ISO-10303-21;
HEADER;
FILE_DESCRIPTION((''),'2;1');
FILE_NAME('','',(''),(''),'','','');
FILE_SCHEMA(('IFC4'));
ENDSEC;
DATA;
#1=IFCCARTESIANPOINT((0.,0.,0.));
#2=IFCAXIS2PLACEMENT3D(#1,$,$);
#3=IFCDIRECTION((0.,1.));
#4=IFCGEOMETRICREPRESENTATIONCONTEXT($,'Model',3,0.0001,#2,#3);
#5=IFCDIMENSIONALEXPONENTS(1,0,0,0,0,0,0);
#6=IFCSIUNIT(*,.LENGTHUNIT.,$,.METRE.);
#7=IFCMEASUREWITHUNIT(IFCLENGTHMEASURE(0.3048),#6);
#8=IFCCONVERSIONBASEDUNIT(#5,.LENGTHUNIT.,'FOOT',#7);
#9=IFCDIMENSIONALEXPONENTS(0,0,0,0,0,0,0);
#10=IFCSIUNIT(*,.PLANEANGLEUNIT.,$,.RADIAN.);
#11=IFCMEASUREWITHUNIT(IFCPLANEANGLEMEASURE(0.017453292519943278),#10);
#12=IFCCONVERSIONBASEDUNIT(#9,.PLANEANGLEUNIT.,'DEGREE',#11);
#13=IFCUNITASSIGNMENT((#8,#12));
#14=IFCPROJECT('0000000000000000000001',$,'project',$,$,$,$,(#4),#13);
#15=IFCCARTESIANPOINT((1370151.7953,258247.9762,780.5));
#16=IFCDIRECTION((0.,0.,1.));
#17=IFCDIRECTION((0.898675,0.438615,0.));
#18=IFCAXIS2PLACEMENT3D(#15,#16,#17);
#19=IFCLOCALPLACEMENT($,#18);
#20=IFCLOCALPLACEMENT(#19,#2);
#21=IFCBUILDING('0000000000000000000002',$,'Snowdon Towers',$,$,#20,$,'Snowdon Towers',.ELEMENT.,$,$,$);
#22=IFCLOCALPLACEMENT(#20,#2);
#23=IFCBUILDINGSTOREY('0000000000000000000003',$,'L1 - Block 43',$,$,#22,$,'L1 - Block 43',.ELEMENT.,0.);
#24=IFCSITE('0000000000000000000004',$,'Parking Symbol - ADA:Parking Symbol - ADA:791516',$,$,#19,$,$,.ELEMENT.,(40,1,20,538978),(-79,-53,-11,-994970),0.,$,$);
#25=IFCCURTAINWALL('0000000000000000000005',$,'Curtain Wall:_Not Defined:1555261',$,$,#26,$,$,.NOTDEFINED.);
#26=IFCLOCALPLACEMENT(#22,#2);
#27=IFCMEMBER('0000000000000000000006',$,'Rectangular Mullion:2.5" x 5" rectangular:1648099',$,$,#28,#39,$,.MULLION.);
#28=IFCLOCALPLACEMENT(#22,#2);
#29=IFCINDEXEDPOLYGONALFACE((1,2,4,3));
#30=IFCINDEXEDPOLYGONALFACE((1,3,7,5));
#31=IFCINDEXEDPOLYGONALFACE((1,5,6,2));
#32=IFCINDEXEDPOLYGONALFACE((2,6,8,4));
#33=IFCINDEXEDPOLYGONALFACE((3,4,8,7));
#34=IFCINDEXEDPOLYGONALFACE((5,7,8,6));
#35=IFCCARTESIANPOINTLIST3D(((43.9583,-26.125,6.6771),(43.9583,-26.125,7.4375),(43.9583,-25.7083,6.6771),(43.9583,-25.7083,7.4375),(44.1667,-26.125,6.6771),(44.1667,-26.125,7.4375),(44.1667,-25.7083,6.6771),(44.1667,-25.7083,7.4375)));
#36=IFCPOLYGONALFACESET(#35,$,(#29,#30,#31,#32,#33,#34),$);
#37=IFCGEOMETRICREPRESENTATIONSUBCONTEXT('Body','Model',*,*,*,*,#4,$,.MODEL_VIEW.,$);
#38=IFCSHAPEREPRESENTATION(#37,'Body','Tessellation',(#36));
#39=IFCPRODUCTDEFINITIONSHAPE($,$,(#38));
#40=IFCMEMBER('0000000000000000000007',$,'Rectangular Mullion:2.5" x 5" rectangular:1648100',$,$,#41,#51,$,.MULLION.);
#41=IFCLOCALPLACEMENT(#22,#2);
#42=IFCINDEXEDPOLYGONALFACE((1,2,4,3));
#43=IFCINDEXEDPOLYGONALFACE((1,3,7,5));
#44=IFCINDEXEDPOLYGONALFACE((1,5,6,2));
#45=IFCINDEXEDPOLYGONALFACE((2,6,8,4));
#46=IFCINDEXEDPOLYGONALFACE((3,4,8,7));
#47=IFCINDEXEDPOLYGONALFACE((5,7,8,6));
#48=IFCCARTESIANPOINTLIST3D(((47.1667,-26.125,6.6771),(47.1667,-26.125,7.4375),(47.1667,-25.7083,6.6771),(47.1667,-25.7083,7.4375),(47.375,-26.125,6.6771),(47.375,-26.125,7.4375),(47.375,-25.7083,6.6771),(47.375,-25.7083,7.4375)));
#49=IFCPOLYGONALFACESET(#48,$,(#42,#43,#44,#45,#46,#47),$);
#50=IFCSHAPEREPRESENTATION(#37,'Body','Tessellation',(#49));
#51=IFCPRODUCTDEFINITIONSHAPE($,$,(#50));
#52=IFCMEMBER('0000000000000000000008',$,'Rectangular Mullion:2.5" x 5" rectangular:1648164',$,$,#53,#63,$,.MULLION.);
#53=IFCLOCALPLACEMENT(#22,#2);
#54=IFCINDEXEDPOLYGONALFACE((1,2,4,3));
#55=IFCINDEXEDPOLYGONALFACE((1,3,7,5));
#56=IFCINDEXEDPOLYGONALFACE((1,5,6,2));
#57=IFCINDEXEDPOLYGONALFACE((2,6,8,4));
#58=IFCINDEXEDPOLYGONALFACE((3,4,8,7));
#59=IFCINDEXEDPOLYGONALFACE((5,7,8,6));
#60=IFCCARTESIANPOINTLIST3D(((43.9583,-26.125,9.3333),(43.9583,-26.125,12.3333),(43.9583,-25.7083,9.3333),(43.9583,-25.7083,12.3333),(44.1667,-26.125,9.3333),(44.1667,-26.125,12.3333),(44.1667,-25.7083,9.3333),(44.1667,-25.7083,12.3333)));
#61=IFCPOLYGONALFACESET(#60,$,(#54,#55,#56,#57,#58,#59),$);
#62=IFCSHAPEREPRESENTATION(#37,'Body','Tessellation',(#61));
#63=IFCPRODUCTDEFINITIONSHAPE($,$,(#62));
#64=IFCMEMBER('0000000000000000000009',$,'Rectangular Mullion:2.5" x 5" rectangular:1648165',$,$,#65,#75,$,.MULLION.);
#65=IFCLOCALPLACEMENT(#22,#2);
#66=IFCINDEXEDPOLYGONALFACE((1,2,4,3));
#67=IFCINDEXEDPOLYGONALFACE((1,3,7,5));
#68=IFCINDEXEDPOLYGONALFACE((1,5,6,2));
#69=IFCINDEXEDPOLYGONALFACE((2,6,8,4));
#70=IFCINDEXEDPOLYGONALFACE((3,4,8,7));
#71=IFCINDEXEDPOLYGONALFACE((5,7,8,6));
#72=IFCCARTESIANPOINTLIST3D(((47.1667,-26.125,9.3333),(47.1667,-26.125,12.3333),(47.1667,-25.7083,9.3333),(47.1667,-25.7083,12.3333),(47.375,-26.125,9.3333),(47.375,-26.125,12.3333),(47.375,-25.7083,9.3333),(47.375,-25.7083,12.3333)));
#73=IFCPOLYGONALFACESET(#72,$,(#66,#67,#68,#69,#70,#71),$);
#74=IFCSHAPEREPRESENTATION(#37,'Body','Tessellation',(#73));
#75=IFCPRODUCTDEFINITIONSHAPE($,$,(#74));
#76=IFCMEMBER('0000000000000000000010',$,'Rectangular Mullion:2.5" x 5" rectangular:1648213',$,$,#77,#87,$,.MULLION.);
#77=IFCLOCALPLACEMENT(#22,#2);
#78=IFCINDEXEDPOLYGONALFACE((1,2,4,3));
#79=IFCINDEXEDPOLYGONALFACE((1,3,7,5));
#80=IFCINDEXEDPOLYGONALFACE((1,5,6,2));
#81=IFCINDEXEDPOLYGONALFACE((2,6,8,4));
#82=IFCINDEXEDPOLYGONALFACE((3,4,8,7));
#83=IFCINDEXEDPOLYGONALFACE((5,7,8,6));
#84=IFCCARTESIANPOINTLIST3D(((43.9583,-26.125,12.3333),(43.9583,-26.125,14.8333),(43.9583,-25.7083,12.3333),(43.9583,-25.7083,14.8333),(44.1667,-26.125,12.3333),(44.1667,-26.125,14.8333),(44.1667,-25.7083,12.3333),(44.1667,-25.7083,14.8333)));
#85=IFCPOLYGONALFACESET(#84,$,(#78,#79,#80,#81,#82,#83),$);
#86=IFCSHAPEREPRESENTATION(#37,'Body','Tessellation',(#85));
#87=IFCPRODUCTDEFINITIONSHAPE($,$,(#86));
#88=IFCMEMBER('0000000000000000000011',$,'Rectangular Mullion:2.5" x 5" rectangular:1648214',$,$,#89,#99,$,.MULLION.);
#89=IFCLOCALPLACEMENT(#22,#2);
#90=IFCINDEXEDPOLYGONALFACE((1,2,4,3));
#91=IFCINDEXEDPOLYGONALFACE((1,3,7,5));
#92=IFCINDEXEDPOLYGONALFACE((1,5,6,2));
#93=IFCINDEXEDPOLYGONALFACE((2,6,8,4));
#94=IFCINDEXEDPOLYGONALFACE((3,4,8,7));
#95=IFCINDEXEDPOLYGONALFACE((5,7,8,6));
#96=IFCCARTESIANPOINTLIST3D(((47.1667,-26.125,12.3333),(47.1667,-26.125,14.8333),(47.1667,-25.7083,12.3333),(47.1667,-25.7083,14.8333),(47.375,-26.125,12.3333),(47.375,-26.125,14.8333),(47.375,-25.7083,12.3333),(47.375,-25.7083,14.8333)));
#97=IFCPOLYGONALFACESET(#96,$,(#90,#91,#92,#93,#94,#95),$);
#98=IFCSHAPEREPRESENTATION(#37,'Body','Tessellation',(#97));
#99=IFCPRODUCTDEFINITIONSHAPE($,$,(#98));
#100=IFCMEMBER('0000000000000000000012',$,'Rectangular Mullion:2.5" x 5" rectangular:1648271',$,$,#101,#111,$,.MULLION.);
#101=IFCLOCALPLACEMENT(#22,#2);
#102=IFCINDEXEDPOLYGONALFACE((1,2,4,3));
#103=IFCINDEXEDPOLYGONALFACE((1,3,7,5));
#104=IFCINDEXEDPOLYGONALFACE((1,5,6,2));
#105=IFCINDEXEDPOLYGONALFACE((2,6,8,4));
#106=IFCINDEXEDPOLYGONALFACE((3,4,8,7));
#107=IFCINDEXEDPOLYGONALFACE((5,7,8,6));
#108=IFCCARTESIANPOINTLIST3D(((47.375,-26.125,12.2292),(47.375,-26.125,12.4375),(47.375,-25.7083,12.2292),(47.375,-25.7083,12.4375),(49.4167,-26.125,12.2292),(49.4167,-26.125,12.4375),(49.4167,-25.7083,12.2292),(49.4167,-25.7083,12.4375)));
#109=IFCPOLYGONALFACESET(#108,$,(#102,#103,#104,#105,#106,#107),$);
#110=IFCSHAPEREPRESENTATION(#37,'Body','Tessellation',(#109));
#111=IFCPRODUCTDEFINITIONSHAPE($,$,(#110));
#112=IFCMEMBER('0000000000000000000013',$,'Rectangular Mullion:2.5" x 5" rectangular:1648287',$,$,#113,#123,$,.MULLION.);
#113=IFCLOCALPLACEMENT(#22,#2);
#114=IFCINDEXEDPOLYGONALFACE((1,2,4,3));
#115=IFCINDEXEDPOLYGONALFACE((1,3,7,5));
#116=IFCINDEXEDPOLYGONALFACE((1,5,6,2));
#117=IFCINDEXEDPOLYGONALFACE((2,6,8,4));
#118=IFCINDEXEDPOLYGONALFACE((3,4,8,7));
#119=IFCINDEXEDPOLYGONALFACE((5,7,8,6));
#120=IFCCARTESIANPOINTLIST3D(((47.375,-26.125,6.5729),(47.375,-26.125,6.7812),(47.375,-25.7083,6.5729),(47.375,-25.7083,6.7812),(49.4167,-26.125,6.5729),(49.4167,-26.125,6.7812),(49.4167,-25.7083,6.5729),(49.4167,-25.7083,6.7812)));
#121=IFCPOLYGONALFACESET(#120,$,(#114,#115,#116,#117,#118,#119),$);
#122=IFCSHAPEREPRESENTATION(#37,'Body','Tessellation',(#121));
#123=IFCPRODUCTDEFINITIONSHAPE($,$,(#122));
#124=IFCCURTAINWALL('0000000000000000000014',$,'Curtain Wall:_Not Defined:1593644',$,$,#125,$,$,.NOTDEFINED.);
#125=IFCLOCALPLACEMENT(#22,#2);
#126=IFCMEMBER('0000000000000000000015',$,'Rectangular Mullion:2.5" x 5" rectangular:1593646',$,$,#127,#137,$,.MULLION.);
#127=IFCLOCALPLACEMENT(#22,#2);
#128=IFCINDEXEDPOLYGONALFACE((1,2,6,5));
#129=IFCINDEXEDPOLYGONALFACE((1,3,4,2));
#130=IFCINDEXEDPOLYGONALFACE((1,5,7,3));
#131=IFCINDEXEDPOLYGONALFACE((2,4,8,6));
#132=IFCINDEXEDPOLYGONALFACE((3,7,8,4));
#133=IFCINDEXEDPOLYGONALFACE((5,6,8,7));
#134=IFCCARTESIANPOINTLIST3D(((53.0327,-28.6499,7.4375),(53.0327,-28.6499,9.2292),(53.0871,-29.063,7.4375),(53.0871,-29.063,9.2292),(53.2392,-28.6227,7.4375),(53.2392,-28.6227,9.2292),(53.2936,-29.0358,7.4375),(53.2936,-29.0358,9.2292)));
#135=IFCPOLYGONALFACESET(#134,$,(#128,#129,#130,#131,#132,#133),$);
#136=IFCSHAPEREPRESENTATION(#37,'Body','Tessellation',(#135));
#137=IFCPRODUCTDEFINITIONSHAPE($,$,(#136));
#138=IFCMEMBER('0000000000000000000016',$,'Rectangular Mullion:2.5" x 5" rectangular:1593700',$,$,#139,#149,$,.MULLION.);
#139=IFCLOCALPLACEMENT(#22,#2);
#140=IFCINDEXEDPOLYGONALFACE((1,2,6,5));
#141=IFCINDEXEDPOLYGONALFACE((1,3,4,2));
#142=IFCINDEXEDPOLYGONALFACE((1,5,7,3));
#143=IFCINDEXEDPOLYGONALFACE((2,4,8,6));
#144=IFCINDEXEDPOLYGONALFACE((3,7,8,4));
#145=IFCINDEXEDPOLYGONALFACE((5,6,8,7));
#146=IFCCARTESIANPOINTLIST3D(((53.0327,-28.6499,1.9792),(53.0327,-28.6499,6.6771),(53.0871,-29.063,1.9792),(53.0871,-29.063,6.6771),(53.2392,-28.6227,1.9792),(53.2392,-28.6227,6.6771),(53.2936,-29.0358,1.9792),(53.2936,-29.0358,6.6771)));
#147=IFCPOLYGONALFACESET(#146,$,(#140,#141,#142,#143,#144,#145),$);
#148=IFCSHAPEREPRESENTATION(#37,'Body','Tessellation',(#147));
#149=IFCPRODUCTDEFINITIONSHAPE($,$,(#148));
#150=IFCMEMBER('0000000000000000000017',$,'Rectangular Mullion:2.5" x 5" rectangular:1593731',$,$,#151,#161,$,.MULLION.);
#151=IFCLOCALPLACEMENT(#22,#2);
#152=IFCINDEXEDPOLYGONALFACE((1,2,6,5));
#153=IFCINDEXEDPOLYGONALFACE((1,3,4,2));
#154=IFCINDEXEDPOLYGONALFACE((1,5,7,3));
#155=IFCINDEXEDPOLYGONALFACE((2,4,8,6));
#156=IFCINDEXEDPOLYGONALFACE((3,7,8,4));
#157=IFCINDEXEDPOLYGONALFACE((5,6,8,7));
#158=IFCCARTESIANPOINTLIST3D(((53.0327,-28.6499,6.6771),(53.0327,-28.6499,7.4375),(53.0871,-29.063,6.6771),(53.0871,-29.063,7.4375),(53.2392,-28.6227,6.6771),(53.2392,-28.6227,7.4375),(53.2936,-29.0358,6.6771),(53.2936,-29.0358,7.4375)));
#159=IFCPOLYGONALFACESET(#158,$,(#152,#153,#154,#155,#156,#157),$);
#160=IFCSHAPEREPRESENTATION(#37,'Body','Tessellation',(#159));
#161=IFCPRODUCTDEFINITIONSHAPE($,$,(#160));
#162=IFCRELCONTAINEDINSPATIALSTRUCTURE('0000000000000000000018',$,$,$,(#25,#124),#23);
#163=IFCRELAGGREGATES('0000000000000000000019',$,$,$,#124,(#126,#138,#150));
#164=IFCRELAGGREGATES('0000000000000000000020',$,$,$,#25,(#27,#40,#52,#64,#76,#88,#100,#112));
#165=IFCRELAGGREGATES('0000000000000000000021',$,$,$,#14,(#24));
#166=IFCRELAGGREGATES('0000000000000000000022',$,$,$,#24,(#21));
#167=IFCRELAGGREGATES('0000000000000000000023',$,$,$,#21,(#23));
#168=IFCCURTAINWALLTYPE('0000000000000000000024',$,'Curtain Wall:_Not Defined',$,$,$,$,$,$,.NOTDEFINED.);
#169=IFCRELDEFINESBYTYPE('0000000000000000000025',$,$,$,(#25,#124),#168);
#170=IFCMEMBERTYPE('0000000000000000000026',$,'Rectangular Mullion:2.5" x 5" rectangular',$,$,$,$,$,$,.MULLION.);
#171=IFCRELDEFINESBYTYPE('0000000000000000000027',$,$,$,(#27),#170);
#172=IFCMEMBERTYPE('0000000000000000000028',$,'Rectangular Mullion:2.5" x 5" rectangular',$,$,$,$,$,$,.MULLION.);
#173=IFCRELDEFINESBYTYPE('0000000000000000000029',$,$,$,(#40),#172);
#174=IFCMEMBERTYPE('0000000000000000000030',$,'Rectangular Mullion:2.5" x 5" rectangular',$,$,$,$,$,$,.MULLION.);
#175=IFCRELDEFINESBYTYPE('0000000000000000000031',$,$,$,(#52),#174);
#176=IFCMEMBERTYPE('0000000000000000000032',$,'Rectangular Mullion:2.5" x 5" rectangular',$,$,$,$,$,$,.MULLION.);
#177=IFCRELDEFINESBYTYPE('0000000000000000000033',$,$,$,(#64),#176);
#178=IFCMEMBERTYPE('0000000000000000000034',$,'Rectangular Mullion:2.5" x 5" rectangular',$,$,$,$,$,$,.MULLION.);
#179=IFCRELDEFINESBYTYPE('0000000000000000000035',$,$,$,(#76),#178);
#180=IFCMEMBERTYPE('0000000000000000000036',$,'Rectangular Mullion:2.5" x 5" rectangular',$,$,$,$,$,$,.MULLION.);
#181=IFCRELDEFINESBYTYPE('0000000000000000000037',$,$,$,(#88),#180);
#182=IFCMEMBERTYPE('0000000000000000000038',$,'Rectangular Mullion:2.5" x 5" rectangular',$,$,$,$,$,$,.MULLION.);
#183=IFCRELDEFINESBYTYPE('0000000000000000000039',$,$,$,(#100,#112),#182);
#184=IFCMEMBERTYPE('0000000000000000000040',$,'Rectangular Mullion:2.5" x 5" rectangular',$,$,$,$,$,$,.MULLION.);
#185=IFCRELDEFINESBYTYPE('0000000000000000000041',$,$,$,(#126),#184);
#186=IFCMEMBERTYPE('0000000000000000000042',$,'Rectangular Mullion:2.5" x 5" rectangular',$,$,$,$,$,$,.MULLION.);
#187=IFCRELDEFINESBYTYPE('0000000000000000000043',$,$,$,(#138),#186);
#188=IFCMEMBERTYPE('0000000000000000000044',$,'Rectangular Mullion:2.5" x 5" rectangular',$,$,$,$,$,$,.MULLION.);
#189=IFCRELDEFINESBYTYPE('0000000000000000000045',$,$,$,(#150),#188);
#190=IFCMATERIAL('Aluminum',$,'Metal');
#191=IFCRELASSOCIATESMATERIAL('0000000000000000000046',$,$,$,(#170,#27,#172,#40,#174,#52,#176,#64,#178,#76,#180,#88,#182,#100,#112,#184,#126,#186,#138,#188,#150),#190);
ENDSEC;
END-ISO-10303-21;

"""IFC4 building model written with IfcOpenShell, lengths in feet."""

from ifc_helpers import new_model, entity, si_unit, converted_unit, direction, frame, origin, place, context, subcontext, project, spatial, indexed_curve, outline, extrude, source, transform, mapped, material, type_object, type_shapes, element, aggregate, save


model = new_model("IFC4")

# Units and contexts
model_context = context("Model", 3, precision=0.0001, world=origin(), true_north=direction((0.0, 1.0)))
body_context = subcontext(model_context, "Body", "Model", "MODEL_VIEW")
ifc_project = project(units=[converted_unit("LENGTHUNIT", "FOOT", entity("IfcLengthMeasure", 0.3048), si_unit("LENGTHUNIT", "METRE"), dimensions=[1, 0, 0, 0, 0, 0, 0]), converted_unit("PLANEANGLEUNIT", "DEGREE", entity("IfcPlaneAngleMeasure", 0.017453292519943278), si_unit("PLANEANGLEUNIT", "RADIAN"), dimensions=[0, 0, 0, 0, 0, 0, 0])], contexts=[model_context])

# Site, building, storey
site_placement = place(None, frame((1370151.7953, 258247.9762, 780.5), z_axis=(0.0, 0.0, 1.0), x_axis=(0.898675, 0.438615, 0.0)))
site = spatial("IfcSite", under=ifc_project, at=site_placement, Name="Parking Symbol - ADA:Parking Symbol - ADA:791516", CompositionType="ELEMENT", RefLatitude=(40, 1, 20, 538978), RefLongitude=(-79, -53, -11, -994970), RefElevation=0.0)
building_placement = place(site_placement, origin())
building = spatial("IfcBuilding", under=site, at=building_placement, Name="Snowdon Towers", LongName="Snowdon Towers", CompositionType="ELEMENT")
storey_placement = place(building_placement, origin())
storey = spatial("IfcBuildingStorey", under=building, at=storey_placement, Name="L1 - Block 43", LongName="L1 - Block 43", CompositionType="ELEMENT", Elevation=0.0)

# Curtain walls, members
curtain_wall_type = type_object("IfcCurtainWallType", Name="Curtain Wall:_Not Defined", PredefinedType="NOTDEFINED")
curtain_wall_1_placement = place(storey_placement, origin())
curtain_wall_1 = element("IfcCurtainWall", 1, at=curtain_wall_1_placement, inside=storey, type_object=curtain_wall_type, Name="Curtain Wall:_Not Defined:1555261", PredefinedType="NOTDEFINED")
ifc_material_1 = material(Name="Aluminum", Category="Metal")
member_type_1 = type_object("IfcMemberType", Name="Rectangular Mullion:2.5\" x 5\" rectangular", PredefinedType="MULLION", material=ifc_material_1)
shared_shape_1 = source(origin(), body_context, "Body", "SweptSolid", [
    extrude(outline(indexed_curve([(-0.1042, -0.2083), (0.1042, -0.2083), (0.1042, 0.2083), (-0.1042, 0.2083), (-0.1042, -0.2083)], self_intersect=False)), frame((-0.1042, 0.0, -0.7604), z_axis=(0.0, 0.0, 1.0), x_axis=(-1.0, 0.0, 0.0)), (0.0, 0.0, 1.0), 0.7604),
])
type_shapes(member_type_1, [shared_shape_1])
member_1_placement = place(curtain_wall_1_placement, frame((43.9583, -25.9167, 6.6771), z_axis=(0.0, 0.0, -1.0), x_axis=(-1.0, 0.0, 0.0)))
member_1 = element("IfcMember", 2, at=member_1_placement, type_object=member_type_1, material=ifc_material_1, Name="Rectangular Mullion:2.5\" x 5\" rectangular:1648099", PredefinedType="MULLION", context=body_context, shape_type="MappedRepresentation", body=[
    mapped(shared_shape_1, transform((0.0, 0.0, 0.0), scale=1.0)),
])
member_type_2 = type_object("IfcMemberType", Name="Rectangular Mullion:2.5\" x 5\" rectangular", PredefinedType="MULLION", material=ifc_material_1)
shared_shape_2 = source(origin(), body_context, "Body", "SweptSolid", [
    extrude(outline(indexed_curve([(-0.1042, -0.2083), (0.1042, -0.2083), (0.1042, 0.2083), (-0.1042, 0.2083), (-0.1042, -0.2083)], self_intersect=False)), frame((0.0, 0.0, -0.7604), z_axis=(0.0, 0.0, 1.0), x_axis=(-1.0, 0.0, 0.0)), (0.0, 0.0, 1.0), 0.7604),
])
type_shapes(member_type_2, [shared_shape_2])
member_2_placement = place(curtain_wall_1_placement, frame((47.2708, -25.9167, 6.6771), z_axis=(0.0, 0.0, -1.0), x_axis=(-1.0, 0.0, 0.0)))
member_2 = element("IfcMember", 3, at=member_2_placement, type_object=member_type_2, material=ifc_material_1, Name="Rectangular Mullion:2.5\" x 5\" rectangular:1648100", PredefinedType="MULLION", context=body_context, shape_type="MappedRepresentation", body=[
    mapped(shared_shape_2, transform((0.0, 0.0, 0.0), scale=1.0)),
])
member_type_3 = type_object("IfcMemberType", Name="Rectangular Mullion:2.5\" x 5\" rectangular", PredefinedType="MULLION", material=ifc_material_1)
shared_shape_3 = source(origin(), body_context, "Body", "SweptSolid", [
    extrude(outline(indexed_curve([(-0.1042, -0.2083), (0.1042, -0.2083), (0.1042, 0.2083), (-0.1042, 0.2083), (-0.1042, -0.2083)], self_intersect=False)), frame((-0.1042, 0.0, -3.0), z_axis=(0.0, 0.0, 1.0), x_axis=(-1.0, 0.0, 0.0)), (0.0, 0.0, 1.0), 3.0),
])
type_shapes(member_type_3, [shared_shape_3])
member_3_placement = place(curtain_wall_1_placement, frame((43.9583, -25.9167, 9.3333), z_axis=(0.0, 0.0, -1.0), x_axis=(-1.0, 0.0, 0.0)))
member_3 = element("IfcMember", 4, at=member_3_placement, type_object=member_type_3, material=ifc_material_1, Name="Rectangular Mullion:2.5\" x 5\" rectangular:1648164", PredefinedType="MULLION", context=body_context, shape_type="MappedRepresentation", body=[
    mapped(shared_shape_3, transform((0.0, 0.0, 0.0), scale=1.0)),
])
member_type_4 = type_object("IfcMemberType", Name="Rectangular Mullion:2.5\" x 5\" rectangular", PredefinedType="MULLION", material=ifc_material_1)
shared_shape_4 = source(origin(), body_context, "Body", "SweptSolid", [
    extrude(outline(indexed_curve([(-0.1042, -0.2083), (0.1042, -0.2083), (0.1042, 0.2083), (-0.1042, 0.2083), (-0.1042, -0.2083)], self_intersect=False)), frame((0.0, 0.0, -3.0), z_axis=(0.0, 0.0, 1.0), x_axis=(-1.0, 0.0, 0.0)), (0.0, 0.0, 1.0), 3.0),
])
type_shapes(member_type_4, [shared_shape_4])
member_4_placement = place(curtain_wall_1_placement, frame((47.2708, -25.9167, 9.3333), z_axis=(0.0, 0.0, -1.0), x_axis=(-1.0, 0.0, 0.0)))
member_4 = element("IfcMember", 5, at=member_4_placement, type_object=member_type_4, material=ifc_material_1, Name="Rectangular Mullion:2.5\" x 5\" rectangular:1648165", PredefinedType="MULLION", context=body_context, shape_type="MappedRepresentation", body=[
    mapped(shared_shape_4, transform((0.0, 0.0, 0.0), scale=1.0)),
])
member_type_5 = type_object("IfcMemberType", Name="Rectangular Mullion:2.5\" x 5\" rectangular", PredefinedType="MULLION", material=ifc_material_1)
shared_shape_5 = source(origin(), body_context, "Body", "SweptSolid", [
    extrude(outline(indexed_curve([(-0.1042, -0.2083), (0.1042, -0.2083), (0.1042, 0.2083), (-0.1042, 0.2083), (-0.1042, -0.2083)], self_intersect=False)), frame((-0.1042, 0.0, -2.5), z_axis=(0.0, 0.0, 1.0), x_axis=(-1.0, 0.0, 0.0)), (0.0, 0.0, 1.0), 2.5),
])
type_shapes(member_type_5, [shared_shape_5])
member_5_placement = place(curtain_wall_1_placement, frame((43.9583, -25.9167, 12.3333), z_axis=(0.0, 0.0, -1.0), x_axis=(-1.0, 0.0, 0.0)))
member_5 = element("IfcMember", 6, at=member_5_placement, type_object=member_type_5, material=ifc_material_1, Name="Rectangular Mullion:2.5\" x 5\" rectangular:1648213", PredefinedType="MULLION", context=body_context, shape_type="MappedRepresentation", body=[
    mapped(shared_shape_5, transform((0.0, 0.0, 0.0), scale=1.0)),
])
member_type_6 = type_object("IfcMemberType", Name="Rectangular Mullion:2.5\" x 5\" rectangular", PredefinedType="MULLION", material=ifc_material_1)
shared_shape_6 = source(origin(), body_context, "Body", "SweptSolid", [
    extrude(outline(indexed_curve([(-0.1042, -0.2083), (0.1042, -0.2083), (0.1042, 0.2083), (-0.1042, 0.2083), (-0.1042, -0.2083)], self_intersect=False)), frame((0.0, 0.0, -2.5), z_axis=(0.0, 0.0, 1.0), x_axis=(-1.0, 0.0, 0.0)), (0.0, 0.0, 1.0), 2.5),
])
type_shapes(member_type_6, [shared_shape_6])
member_6_placement = place(curtain_wall_1_placement, frame((47.2708, -25.9167, 12.3333), z_axis=(0.0, 0.0, -1.0), x_axis=(-1.0, 0.0, 0.0)))
member_6 = element("IfcMember", 7, at=member_6_placement, type_object=member_type_6, material=ifc_material_1, Name="Rectangular Mullion:2.5\" x 5\" rectangular:1648214", PredefinedType="MULLION", context=body_context, shape_type="MappedRepresentation", body=[
    mapped(shared_shape_6, transform((0.0, 0.0, 0.0), scale=1.0)),
])
member_type_7 = type_object("IfcMemberType", Name="Rectangular Mullion:2.5\" x 5\" rectangular", PredefinedType="MULLION", material=ifc_material_1)
shared_shape_7 = source(origin(), body_context, "Body", "SweptSolid", [
    extrude(outline(indexed_curve([(-0.1042, -0.2083), (0.1042, -0.2083), (0.1042, 0.2083), (-0.1042, 0.2083), (-0.1042, -0.2083)], self_intersect=False)), frame((0.0, 0.0, -2.0417), z_axis=(0.0, 0.0, 1.0), x_axis=(-1.0, 0.0, 0.0)), (0.0, 0.0, 1.0), 2.0417),
])
type_shapes(member_type_7, [shared_shape_7])
member_7_placement = place(curtain_wall_1_placement, frame((47.375, -25.9167, 12.3333), z_axis=(-1.0, 0.0, 0.0), x_axis=(0.0, 0.0, 1.0)))
member_7 = element("IfcMember", 8, at=member_7_placement, type_object=member_type_7, material=ifc_material_1, Name="Rectangular Mullion:2.5\" x 5\" rectangular:1648271", PredefinedType="MULLION", context=body_context, shape_type="MappedRepresentation", body=[
    mapped(shared_shape_7, transform((0.0, 0.0, 0.0), scale=1.0)),
])
member_8_placement = place(curtain_wall_1_placement, frame((47.375, -25.9167, 6.6771), z_axis=(-1.0, 0.0, 0.0), x_axis=(0.0, 0.0, 1.0)))
member_8 = element("IfcMember", 9, at=member_8_placement, type_object=member_type_7, material=ifc_material_1, Name="Rectangular Mullion:2.5\" x 5\" rectangular:1648287", PredefinedType="MULLION", context=body_context, shape_type="MappedRepresentation", body=[
    mapped(shared_shape_7, transform((0.0, 0.0, 0.0), scale=1.0)),
])
curtain_wall_2_placement = place(storey_placement, origin())
curtain_wall_2 = element("IfcCurtainWall", 10, at=curtain_wall_2_placement, inside=storey, type_object=curtain_wall_type, Name="Curtain Wall:_Not Defined:1593644", PredefinedType="NOTDEFINED")
member_type_8 = type_object("IfcMemberType", Name="Rectangular Mullion:2.5\" x 5\" rectangular", PredefinedType="MULLION", material=ifc_material_1)
shared_shape_8 = source(origin(), body_context, "Body", "SweptSolid", [
    extrude(outline(indexed_curve([(-0.1042, -0.2083), (0.1042, -0.2083), (0.1042, 0.2083), (-0.1042, 0.2083), (-0.1042, -0.2083)], self_intersect=False)), frame((-0.1042, 0.0, -1.7917), z_axis=(0.0, 0.0, 1.0), x_axis=(-1.0, 0.0, 0.0)), (0.0, 0.0, 1.0), 1.7917),
])
type_shapes(member_type_8, [shared_shape_8])
member_9_placement = place(curtain_wall_2_placement, frame((53.0599, -28.8565, 9.2292), z_axis=(0.0, 0.0, 1.0), x_axis=(-0.991445, -0.130526, 0.0)))
member_9 = element("IfcMember", 11, at=member_9_placement, type_object=member_type_8, material=ifc_material_1, Name="Rectangular Mullion:2.5\" x 5\" rectangular:1593646", PredefinedType="MULLION", context=body_context, shape_type="MappedRepresentation", body=[
    mapped(shared_shape_8, transform((0.0, 0.0, 0.0), scale=1.0)),
])
member_type_9 = type_object("IfcMemberType", Name="Rectangular Mullion:2.5\" x 5\" rectangular", PredefinedType="MULLION", material=ifc_material_1)
shared_shape_9 = source(origin(), body_context, "Body", "SweptSolid", [
    extrude(outline(indexed_curve([(-0.1042, -0.2083), (0.1042, -0.2083), (0.1042, 0.2083), (-0.1042, 0.2083), (-0.1042, -0.2083)], self_intersect=False)), frame((-0.1042, 0.0, -4.6979), z_axis=(0.0, 0.0, 1.0), x_axis=(-1.0, 0.0, 0.0)), (0.0, 0.0, 1.0), 4.6979),
])
type_shapes(member_type_9, [shared_shape_9])
member_10_placement = place(curtain_wall_2_placement, frame((53.0599, -28.8565, 6.6771), z_axis=(0.0, 0.0, 1.0), x_axis=(-0.991445, -0.130526, 0.0)))
member_10 = element("IfcMember", 12, at=member_10_placement, type_object=member_type_9, material=ifc_material_1, Name="Rectangular Mullion:2.5\" x 5\" rectangular:1593700", PredefinedType="MULLION", context=body_context, shape_type="MappedRepresentation", body=[
    mapped(shared_shape_9, transform((0.0, 0.0, 0.0), scale=1.0)),
])
member_type_10 = type_object("IfcMemberType", Name="Rectangular Mullion:2.5\" x 5\" rectangular", PredefinedType="MULLION", material=ifc_material_1)
shared_shape_10 = source(origin(), body_context, "Body", "SweptSolid", [
    extrude(outline(indexed_curve([(-0.1042, -0.2083), (0.1042, -0.2083), (0.1042, 0.2083), (-0.1042, 0.2083), (-0.1042, -0.2083)], self_intersect=False)), frame((-0.1042, 0.0, -0.7604), z_axis=(0.0, 0.0, 1.0), x_axis=(-1.0, 0.0, 0.0)), (0.0, 0.0, 1.0), 0.7604),
])
type_shapes(member_type_10, [shared_shape_10])
member_11_placement = place(curtain_wall_2_placement, frame((53.0599, -28.8565, 7.4375), z_axis=(0.0, 0.0, 1.0), x_axis=(-0.991445, -0.130526, 0.0)))
member_11 = element("IfcMember", 13, at=member_11_placement, type_object=member_type_10, material=ifc_material_1, Name="Rectangular Mullion:2.5\" x 5\" rectangular:1593731", PredefinedType="MULLION", context=body_context, shape_type="MappedRepresentation", body=[
    mapped(shared_shape_10, transform((0.0, 0.0, 0.0), scale=1.0)),
])

aggregate(curtain_wall_2, [member_9, member_10, member_11])

aggregate(curtain_wall_1, [member_1, member_2, member_3, member_4, member_5, member_6, member_7, member_8])

save(model, "model.ifc")
